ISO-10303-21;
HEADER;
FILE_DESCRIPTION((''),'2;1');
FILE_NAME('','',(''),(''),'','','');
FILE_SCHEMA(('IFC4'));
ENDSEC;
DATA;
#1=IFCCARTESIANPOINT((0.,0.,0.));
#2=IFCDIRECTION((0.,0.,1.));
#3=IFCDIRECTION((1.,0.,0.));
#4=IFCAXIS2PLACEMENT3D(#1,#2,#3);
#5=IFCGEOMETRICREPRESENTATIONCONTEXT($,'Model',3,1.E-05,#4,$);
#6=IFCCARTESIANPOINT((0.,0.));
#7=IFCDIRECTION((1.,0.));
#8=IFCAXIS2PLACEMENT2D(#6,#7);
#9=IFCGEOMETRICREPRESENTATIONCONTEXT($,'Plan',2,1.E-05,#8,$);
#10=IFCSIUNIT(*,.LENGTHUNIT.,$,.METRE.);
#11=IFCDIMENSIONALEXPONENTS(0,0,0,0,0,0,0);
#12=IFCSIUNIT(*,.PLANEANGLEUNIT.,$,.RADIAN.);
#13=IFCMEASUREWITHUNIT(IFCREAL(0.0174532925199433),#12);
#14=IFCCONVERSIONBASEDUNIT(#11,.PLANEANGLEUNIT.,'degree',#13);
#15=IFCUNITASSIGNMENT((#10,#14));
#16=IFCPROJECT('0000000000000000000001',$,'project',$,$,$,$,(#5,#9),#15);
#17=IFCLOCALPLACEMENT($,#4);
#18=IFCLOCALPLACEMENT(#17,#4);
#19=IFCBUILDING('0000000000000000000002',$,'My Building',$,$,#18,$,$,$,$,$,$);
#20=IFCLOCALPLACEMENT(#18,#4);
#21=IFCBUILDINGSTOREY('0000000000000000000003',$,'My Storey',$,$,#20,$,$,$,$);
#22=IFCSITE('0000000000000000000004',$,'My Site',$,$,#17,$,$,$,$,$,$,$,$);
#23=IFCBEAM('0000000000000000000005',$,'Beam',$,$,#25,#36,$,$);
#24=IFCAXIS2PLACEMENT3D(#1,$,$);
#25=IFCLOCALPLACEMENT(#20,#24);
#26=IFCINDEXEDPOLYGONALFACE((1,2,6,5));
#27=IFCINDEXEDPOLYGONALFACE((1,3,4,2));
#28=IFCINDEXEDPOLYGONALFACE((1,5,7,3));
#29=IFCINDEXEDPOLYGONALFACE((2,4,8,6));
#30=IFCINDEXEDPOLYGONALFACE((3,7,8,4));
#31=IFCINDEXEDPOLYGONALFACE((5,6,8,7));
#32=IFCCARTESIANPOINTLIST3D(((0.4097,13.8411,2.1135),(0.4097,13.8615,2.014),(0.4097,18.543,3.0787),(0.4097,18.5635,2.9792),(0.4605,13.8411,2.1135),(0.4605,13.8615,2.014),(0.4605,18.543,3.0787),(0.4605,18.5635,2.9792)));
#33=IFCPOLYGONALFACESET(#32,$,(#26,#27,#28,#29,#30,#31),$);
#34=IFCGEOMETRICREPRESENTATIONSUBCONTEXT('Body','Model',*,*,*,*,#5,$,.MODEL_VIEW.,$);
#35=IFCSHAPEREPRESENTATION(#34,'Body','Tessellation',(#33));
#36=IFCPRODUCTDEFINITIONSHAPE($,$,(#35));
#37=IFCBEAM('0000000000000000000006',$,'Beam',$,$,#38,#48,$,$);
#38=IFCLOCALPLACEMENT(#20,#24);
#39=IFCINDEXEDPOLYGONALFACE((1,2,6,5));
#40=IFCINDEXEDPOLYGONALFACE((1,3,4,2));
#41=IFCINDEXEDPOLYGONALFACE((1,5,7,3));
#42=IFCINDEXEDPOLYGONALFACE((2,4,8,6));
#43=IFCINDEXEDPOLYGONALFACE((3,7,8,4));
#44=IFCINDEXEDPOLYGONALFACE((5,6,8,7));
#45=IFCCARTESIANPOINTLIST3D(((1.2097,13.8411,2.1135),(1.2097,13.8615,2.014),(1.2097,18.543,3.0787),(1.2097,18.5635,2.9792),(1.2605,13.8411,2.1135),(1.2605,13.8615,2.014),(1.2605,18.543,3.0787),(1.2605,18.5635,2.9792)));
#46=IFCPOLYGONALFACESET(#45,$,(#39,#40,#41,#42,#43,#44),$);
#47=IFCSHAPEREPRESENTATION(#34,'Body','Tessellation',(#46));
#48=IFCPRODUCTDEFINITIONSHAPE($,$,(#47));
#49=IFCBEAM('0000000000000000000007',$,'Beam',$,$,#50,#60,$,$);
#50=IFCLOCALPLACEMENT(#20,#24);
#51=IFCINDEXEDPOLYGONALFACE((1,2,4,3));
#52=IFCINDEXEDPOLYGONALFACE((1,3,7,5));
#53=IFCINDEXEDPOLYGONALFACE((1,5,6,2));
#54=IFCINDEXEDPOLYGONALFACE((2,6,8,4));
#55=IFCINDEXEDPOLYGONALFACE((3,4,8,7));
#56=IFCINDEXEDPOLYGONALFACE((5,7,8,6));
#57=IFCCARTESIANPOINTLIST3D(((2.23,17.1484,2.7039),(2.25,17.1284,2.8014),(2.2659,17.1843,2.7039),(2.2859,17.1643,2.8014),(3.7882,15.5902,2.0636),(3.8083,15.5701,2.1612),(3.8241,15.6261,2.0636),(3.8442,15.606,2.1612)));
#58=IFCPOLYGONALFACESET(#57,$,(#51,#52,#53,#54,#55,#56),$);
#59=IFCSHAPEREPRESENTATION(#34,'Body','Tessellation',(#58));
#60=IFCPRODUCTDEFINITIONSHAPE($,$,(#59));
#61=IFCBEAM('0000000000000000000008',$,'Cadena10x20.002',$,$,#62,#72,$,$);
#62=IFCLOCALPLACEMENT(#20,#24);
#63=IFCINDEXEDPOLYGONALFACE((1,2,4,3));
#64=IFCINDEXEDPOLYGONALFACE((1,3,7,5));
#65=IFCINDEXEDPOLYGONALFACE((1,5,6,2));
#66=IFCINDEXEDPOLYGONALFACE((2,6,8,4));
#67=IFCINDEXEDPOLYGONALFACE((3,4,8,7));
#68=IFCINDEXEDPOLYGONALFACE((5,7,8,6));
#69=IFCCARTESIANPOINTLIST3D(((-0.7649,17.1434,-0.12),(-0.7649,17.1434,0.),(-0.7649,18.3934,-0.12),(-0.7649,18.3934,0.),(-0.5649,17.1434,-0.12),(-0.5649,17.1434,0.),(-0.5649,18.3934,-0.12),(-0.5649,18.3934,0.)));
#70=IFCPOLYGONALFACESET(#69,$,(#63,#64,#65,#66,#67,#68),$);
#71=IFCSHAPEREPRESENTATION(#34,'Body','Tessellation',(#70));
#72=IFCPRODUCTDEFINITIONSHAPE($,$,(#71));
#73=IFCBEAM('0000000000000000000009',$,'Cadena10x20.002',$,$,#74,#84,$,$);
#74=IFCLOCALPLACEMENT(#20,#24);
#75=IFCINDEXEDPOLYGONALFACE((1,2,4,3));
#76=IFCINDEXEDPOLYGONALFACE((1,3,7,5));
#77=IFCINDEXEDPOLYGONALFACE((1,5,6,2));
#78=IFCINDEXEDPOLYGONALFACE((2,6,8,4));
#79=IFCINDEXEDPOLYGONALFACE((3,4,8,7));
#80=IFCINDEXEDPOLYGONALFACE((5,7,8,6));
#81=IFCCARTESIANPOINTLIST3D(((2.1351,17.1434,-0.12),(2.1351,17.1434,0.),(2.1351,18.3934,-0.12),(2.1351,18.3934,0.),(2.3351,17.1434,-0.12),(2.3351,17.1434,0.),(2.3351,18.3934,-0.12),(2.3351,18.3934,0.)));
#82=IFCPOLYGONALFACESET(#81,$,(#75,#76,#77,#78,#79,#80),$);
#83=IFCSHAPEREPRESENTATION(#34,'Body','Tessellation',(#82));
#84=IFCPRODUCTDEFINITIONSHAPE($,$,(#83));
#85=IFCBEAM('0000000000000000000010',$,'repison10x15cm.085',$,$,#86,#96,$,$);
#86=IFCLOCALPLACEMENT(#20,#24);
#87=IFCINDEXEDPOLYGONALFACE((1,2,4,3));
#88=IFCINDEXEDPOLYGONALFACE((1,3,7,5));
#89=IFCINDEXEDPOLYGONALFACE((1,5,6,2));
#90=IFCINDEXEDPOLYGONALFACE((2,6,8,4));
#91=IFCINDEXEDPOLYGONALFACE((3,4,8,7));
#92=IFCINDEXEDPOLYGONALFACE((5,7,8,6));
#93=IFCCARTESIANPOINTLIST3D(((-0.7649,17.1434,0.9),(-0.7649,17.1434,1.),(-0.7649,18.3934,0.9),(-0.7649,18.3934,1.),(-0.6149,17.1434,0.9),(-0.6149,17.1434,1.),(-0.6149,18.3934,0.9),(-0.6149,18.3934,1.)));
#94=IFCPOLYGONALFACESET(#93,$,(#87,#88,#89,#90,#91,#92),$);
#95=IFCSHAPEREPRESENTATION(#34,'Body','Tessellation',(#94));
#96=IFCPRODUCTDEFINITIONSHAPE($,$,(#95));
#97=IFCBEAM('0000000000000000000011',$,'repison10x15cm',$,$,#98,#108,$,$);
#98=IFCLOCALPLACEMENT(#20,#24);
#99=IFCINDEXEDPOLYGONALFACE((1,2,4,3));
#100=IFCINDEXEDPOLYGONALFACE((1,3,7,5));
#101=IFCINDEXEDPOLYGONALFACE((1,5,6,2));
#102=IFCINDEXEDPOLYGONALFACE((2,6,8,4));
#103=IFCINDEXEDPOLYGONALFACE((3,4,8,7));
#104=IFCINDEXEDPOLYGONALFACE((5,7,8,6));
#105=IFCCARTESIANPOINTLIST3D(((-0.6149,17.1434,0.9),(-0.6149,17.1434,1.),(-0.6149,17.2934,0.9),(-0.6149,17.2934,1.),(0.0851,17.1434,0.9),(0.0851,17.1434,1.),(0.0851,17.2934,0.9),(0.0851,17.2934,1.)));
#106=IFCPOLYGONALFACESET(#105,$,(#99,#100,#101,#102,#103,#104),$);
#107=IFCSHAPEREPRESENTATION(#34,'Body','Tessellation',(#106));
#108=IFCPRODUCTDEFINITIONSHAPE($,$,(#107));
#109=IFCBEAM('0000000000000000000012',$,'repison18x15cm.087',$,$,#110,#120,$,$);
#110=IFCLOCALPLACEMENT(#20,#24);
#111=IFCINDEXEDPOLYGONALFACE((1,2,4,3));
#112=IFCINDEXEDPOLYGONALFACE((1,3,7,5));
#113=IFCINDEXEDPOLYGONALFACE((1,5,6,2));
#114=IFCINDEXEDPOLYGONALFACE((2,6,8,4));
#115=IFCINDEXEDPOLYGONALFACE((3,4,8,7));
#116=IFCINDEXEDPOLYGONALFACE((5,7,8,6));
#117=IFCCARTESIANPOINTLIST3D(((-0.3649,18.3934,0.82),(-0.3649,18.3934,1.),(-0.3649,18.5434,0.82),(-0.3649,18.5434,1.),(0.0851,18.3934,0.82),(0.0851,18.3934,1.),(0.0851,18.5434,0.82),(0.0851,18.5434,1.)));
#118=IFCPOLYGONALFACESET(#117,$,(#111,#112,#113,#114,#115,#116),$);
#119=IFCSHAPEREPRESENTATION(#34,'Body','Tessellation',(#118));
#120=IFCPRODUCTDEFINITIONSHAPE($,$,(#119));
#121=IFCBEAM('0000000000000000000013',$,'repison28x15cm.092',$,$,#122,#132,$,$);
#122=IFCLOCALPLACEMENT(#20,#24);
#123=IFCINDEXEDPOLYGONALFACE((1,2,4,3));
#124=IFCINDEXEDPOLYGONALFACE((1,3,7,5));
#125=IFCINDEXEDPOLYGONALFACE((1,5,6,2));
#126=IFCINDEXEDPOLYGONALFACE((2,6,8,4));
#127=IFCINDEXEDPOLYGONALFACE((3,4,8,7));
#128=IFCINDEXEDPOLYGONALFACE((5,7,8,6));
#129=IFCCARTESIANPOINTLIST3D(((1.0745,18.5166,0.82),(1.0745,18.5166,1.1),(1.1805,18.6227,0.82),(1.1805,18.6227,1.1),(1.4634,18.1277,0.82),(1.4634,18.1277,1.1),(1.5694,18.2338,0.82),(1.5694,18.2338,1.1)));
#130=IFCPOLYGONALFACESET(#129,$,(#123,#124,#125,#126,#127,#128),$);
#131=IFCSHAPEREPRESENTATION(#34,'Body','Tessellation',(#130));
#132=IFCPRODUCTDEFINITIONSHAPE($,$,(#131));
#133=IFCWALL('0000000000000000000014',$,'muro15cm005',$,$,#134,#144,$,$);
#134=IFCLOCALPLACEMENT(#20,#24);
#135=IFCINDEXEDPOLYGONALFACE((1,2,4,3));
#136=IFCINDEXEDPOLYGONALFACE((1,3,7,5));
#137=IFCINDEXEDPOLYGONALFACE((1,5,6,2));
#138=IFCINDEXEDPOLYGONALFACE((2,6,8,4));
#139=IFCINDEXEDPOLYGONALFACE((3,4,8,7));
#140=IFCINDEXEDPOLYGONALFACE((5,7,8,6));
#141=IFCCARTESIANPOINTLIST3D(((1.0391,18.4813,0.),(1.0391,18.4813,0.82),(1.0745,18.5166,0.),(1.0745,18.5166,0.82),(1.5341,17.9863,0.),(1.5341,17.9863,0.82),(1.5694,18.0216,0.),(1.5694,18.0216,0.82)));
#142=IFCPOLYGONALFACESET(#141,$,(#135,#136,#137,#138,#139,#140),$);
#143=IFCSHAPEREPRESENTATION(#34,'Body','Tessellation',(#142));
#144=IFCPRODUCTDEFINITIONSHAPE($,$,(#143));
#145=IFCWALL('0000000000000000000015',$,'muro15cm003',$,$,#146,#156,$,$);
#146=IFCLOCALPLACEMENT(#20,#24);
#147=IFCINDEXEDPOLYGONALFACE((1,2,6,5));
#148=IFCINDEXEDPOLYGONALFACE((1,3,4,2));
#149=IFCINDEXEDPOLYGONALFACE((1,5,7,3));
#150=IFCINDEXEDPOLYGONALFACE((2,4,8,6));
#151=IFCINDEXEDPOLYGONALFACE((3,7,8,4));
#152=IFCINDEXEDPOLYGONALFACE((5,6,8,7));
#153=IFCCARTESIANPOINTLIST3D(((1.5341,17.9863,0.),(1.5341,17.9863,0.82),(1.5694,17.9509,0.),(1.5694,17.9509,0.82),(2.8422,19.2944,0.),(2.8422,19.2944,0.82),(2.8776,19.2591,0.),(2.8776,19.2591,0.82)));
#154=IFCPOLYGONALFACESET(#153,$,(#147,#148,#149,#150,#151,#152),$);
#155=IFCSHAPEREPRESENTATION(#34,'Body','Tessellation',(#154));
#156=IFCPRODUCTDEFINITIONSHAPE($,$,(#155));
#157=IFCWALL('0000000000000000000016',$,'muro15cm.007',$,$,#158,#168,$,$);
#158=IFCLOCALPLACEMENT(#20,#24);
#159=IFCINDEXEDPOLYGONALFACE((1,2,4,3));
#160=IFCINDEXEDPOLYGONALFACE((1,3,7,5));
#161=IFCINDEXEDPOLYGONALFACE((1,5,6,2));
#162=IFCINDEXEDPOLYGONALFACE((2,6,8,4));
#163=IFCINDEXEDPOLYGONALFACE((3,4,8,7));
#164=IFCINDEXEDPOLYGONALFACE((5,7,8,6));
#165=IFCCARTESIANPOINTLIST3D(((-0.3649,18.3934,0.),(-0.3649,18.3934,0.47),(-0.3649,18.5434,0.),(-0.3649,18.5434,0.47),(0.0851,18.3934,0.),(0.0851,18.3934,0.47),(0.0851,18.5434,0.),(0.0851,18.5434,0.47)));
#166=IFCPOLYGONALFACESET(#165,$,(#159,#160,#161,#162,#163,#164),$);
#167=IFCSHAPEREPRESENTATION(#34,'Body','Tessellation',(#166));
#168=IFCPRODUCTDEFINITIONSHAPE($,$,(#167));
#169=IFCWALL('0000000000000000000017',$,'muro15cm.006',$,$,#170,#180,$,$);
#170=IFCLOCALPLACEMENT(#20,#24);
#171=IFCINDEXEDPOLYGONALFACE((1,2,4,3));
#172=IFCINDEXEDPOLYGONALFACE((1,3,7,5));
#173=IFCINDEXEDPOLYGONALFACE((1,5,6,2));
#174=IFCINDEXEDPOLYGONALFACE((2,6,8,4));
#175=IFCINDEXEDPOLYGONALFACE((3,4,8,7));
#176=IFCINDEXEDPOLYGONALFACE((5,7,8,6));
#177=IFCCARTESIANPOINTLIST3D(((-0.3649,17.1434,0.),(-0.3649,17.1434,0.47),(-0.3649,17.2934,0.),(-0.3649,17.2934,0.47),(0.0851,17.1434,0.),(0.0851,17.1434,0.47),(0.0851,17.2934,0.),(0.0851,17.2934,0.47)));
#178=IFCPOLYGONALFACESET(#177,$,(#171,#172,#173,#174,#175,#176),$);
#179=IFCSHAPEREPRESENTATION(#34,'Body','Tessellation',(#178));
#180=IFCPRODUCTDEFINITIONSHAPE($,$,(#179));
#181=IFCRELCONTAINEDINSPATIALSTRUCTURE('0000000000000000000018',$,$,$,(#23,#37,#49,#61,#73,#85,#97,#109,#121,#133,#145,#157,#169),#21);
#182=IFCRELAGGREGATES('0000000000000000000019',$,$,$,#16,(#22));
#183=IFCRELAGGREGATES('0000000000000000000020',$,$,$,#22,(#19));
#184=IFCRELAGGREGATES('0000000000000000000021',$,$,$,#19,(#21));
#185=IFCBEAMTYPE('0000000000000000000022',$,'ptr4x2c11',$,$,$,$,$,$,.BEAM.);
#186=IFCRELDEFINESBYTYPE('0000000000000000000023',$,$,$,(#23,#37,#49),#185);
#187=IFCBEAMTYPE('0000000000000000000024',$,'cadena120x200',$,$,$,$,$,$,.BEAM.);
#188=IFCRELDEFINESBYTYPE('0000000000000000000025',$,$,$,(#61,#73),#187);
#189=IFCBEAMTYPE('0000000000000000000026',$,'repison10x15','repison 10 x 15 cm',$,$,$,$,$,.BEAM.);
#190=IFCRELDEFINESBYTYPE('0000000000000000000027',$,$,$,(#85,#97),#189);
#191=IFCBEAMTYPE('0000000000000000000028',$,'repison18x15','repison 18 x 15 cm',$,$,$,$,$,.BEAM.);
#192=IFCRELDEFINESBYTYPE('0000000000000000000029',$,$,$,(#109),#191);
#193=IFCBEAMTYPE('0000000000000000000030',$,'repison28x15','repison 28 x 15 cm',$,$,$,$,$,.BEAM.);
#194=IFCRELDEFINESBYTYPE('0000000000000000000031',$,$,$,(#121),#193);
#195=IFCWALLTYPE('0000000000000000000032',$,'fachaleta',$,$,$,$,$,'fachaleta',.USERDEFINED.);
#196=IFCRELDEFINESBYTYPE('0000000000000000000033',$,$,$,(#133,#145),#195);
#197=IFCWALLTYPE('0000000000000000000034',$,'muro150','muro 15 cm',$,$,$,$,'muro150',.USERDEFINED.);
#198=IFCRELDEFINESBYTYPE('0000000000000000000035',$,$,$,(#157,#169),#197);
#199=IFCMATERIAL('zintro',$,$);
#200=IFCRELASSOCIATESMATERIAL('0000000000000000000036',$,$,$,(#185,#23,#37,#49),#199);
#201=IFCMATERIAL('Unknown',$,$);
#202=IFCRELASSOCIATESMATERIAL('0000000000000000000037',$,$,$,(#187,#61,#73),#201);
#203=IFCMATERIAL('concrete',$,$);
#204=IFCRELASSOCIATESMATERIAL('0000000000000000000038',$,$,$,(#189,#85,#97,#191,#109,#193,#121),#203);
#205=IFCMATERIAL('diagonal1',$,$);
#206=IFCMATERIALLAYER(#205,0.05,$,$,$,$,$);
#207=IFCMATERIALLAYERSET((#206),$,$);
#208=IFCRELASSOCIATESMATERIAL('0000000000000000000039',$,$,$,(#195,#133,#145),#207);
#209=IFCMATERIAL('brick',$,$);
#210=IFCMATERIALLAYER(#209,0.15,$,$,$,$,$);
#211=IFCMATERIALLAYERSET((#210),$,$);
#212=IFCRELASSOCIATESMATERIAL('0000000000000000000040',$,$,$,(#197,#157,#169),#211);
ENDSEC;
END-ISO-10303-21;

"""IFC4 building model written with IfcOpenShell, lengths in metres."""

from ifc_helpers import new_model, entity, si_unit, converted_unit, frame, origin_with_axes, origin_2d_with_axis, place, context, subcontext, project, spatial, indexed_curve, rectangle, outline, extrude, material, layer, layer_set, layer_usage, material_profile, profile_set, profile_usage, type_object, element, save


model = new_model("IFC4")

# Units and contexts
model_context = context("Model", 3, precision=1e-05, world=origin_with_axes())
plan_context = context("Plan", 2, precision=1e-05, world=origin_2d_with_axis())
body_context = subcontext(model_context, "Body", "Model", "MODEL_VIEW")
ifc_project = project(units=[si_unit("LENGTHUNIT", "METRE"), converted_unit("PLANEANGLEUNIT", "degree", entity("IfcReal", 0.0174532925199433), si_unit("PLANEANGLEUNIT", "RADIAN"), dimensions=[0, 0, 0, 0, 0, 0, 0])], contexts=[model_context, plan_context])

# Site, building, storey
site_placement = place(None, origin_with_axes())
site = spatial("IfcSite", under=ifc_project, at=site_placement, Name="My Site")
building_placement = place(site_placement, origin_with_axes())
building = spatial("IfcBuilding", under=site, at=building_placement, Name="My Building")
storey_placement = place(building_placement, origin_with_axes())
storey = spatial("IfcBuildingStorey", under=building, at=storey_placement, Name="My Storey")

# Shared definitions
ifc_material_1 = material(Name="concrete")

# Beams
ifc_material_2 = material(Name="zintro")
ifc_material_profile_1 = material_profile(ifc_material_2, rectangle(XDim=0.0508, YDim=0.1016))
ifc_profile_set_1 = profile_set([ifc_material_profile_1])
beam_type_1 = type_object("IfcBeamType", Name="ptr4x2c11", PredefinedType="BEAM", material=ifc_profile_set_1)
ifc_profile_usage_1 = profile_usage(ifc_profile_set_1)
beam_1_placement = place(storey_placement, frame((0.4351, 18.5532, 3.0289), z_axis=(0.0, -0.979575, -0.201078), x_axis=(1.0, 0.0, 0.0)))
element("IfcBeam", 1, at=beam_1_placement, inside=storey, type_object=beam_type_1, material=ifc_profile_usage_1, Name="Beam", context=body_context, shape_type="SweptSolid", body=[
    extrude(rectangle(XDim=0.0508, YDim=0.1016), origin_with_axes(), (0.0, 0.0, 1.0), 4.8),
])
ifc_profile_usage_2 = profile_usage(ifc_profile_set_1)
beam_2_placement = place(storey_placement, frame((1.2351, 18.5532, 3.0289), z_axis=(0.0, -0.979575, -0.201078), x_axis=(1.0, 0.0, 0.0)))
element("IfcBeam", 2, at=beam_2_placement, inside=storey, type_object=beam_type_1, material=ifc_profile_usage_2, Name="Beam", context=body_context, shape_type="SweptSolid", body=[
    extrude(rectangle(XDim=0.0508, YDim=0.1016), origin_with_axes(), (0.0, 0.0, 1.0), 4.8),
])
ifc_profile_usage_3 = profile_usage(ifc_profile_set_1)
beam_3_placement = place(storey_placement, frame((2.2579, 17.1564, 2.7527), z_axis=(0.67903, -0.67903, -0.278991), x_axis=(0.707107, 0.707107, 0.0)))
element("IfcBeam", 3, at=beam_3_placement, inside=storey, type_object=beam_type_1, material=ifc_profile_usage_3, Name="Beam", context=body_context, shape_type="SweptSolid", body=[
    extrude(rectangle(XDim=0.0508, YDim=0.1016), origin_with_axes(), (0.0, 0.0, 1.0), 2.2948),
])
ifc_material_3 = material(Name="Unknown")
ifc_material_profile_2 = material_profile(ifc_material_3, rectangle(XDim=0.2, YDim=0.12))
ifc_profile_set_2 = profile_set([ifc_material_profile_2], Name="concrete")
ifc_profile_usage_4 = profile_usage(ifc_profile_set_2, cardinal=5)
beam_type_2 = type_object("IfcBeamType", Name="cadena120x200", PredefinedType="BEAM", material=ifc_profile_set_2)
beam_4_placement = place(storey_placement, frame((-0.6649, 18.3934, -0.06), z_axis=(0.0, -1.0, 0.0), x_axis=(1.0, 0.0, 0.0)))
element("IfcBeam", 4, at=beam_4_placement, inside=storey, type_object=beam_type_2, material=ifc_profile_usage_4, Name="Cadena10x20.002", context=body_context, shape_type="SweptSolid", body=[
    extrude(rectangle(XDim=0.2, YDim=0.12), origin_with_axes(), (0.0, 0.0, 1.0), 1.25),
])
ifc_profile_usage_5 = profile_usage(ifc_profile_set_2, cardinal=5)
beam_5_placement = place(storey_placement, frame((2.2351, 18.3934, -0.06), z_axis=(0.0, -1.0, 0.0), x_axis=(1.0, 0.0, 0.0)))
element("IfcBeam", 5, at=beam_5_placement, inside=storey, type_object=beam_type_2, material=ifc_profile_usage_5, Name="Cadena10x20.002", context=body_context, shape_type="SweptSolid", body=[
    extrude(rectangle(XDim=0.2, YDim=0.12), origin_with_axes(), (0.0, 0.0, 1.0), 1.25),
])
ifc_material_profile_3 = material_profile(ifc_material_1, rectangle(XDim=0.15, YDim=0.1))
ifc_profile_set_3 = profile_set([ifc_material_profile_3])
ifc_profile_usage_6 = profile_usage(ifc_profile_set_3, cardinal=5)
beam_type_3 = type_object("IfcBeamType", Name="repison10x15", Description="repison 10 x 15 cm", PredefinedType="BEAM", material=ifc_profile_set_3)
beam_6_placement = place(storey_placement, frame((-0.6899, 18.3934, 0.95), z_axis=(0.0, -1.0, 0.0), x_axis=(1.0, 0.0, 0.0)))
element("IfcBeam", 6, at=beam_6_placement, inside=storey, type_object=beam_type_3, material=ifc_profile_usage_6, Name="repison10x15cm.085", context=body_context, shape_type="SweptSolid", body=[
    extrude(rectangle(XDim=0.15, YDim=0.1), origin_with_axes(), (0.0, 0.0, 1.0), 1.25),
])
ifc_profile_usage_7 = profile_usage(ifc_profile_set_3, cardinal=5)
beam_7_placement = place(storey_placement, frame((-0.6149, 17.2184, 0.95), z_axis=(1.0, 0.0, 0.0), x_axis=(0.0, 1.0, 0.0)))
element("IfcBeam", 7, at=beam_7_placement, inside=storey, type_object=beam_type_3, material=ifc_profile_usage_7, Name="repison10x15cm", context=body_context, shape_type="SweptSolid", body=[
    extrude(rectangle(XDim=0.15, YDim=0.1), origin_with_axes(), (0.0, 0.0, 1.0), 0.7),
])
ifc_material_profile_4 = material_profile(ifc_material_1, rectangle(XDim=0.15, YDim=0.18), Name="concrete")
ifc_profile_set_4 = profile_set([ifc_material_profile_4], Name="concrete")
ifc_profile_usage_8 = profile_usage(ifc_profile_set_4, cardinal=5)
beam_type_4 = type_object("IfcBeamType", Name="repison18x15", Description="repison 18 x 15 cm", PredefinedType="BEAM", material=ifc_profile_set_4)
beam_8_placement = place(storey_placement, frame((-0.3649, 18.4684, 0.91), z_axis=(1.0, 0.0, 0.0), x_axis=(0.0, 1.0, 0.0)))
element("IfcBeam", 8, at=beam_8_placement, inside=storey, type_object=beam_type_4, material=ifc_profile_usage_8, Name="repison18x15cm.087", context=body_context, shape_type="SweptSolid", body=[
    extrude(rectangle(XDim=0.15, YDim=0.18), origin_with_axes(), (0.0, 0.0, 1.0), 0.45),
])
ifc_material_profile_5 = material_profile(ifc_material_1, rectangle(XDim=0.15, YDim=0.28))
ifc_profile_set_5 = profile_set([ifc_material_profile_5])
ifc_profile_usage_9 = profile_usage(ifc_profile_set_5, cardinal=5)
beam_type_5 = type_object("IfcBeamType", Name="repison28x15", Description="repison 28 x 15 cm", PredefinedType="BEAM", material=ifc_profile_set_5)
beam_9_placement = place(storey_placement, frame((1.1275, 18.5697, 0.96), z_axis=(0.707107, -0.707107, 0.0), x_axis=(0.707107, 0.707107, 0.0)))
element("IfcBeam", 9, at=beam_9_placement, inside=storey, type_object=beam_type_5, material=ifc_profile_usage_9, Name="repison28x15cm.092", context=body_context, shape_type="SweptSolid", body=[
    extrude(rectangle(XDim=0.15, YDim=0.28), origin_with_axes(), (0.0, 0.0, 1.0), 0.55),
])

# Walls
ifc_material_4 = material(Name="diagonal1")
ifc_layer_1 = layer(ifc_material_4, 0.05)
ifc_layer_set_1 = layer_set([ifc_layer_1])
ifc_layer_usage_1 = layer_usage(ifc_layer_set_1, "AXIS2", "POSITIVE", 0.0)
wall_type_1 = type_object("IfcWallType", Name="fachaleta", ElementType="fachaleta", PredefinedType="USERDEFINED", material=ifc_layer_set_1)
wall_1_placement = place(storey_placement, frame((1.0391, 18.4813, 0.0), z_axis=(0.0, 0.0, 1.0), x_axis=(0.707107, -0.707107, 0.0)))
element("IfcWall", 10, at=wall_1_placement, inside=storey, type_object=wall_type_1, material=ifc_layer_usage_1, Name="muro15cm005", context=body_context, shape_type="SweptSolid", body=[
    extrude(outline(indexed_curve([(0.0, 0.0), (0.0, 0.05), (0.7, 0.05), (0.7, 0.0), (0.0, 0.0)], self_intersect=False)), origin_with_axes(), (0.0, 0.0, 1.0), 0.82),
])
ifc_layer_usage_2 = layer_usage(ifc_layer_set_1, "AXIS2", "POSITIVE", 0.0)
wall_2_placement = place(storey_placement, frame((1.5694, 17.9509, 0.0), z_axis=(0.0, 0.0, 1.0), x_axis=(0.707107, 0.707107, 0.0)))
element("IfcWall", 11, at=wall_2_placement, inside=storey, type_object=wall_type_1, material=ifc_layer_usage_2, Name="muro15cm003", context=body_context, shape_type="SweptSolid", body=[
    extrude(outline(indexed_curve([(0.0, 0.0), (0.0, 0.05), (1.85, 0.05), (1.85, 0.0), (0.0, 0.0)], self_intersect=False)), origin_with_axes(), (0.0, 0.0, 1.0), 0.82),
])
ifc_material_5 = material(Name="brick")
ifc_layer_2 = layer(ifc_material_5, 0.15)
ifc_layer_set_2 = layer_set([ifc_layer_2])
ifc_layer_usage_3 = layer_usage(ifc_layer_set_2, "AXIS2", "POSITIVE", 0.0)
wall_type_2 = type_object("IfcWallType", Name="muro150", Description="muro 15 cm", ElementType="muro150", PredefinedType="USERDEFINED", material=ifc_layer_set_2)
wall_3_placement = place(storey_placement, frame((-0.3649, 18.3934, 0.0), z_axis=(0.0, 0.0, 1.0), x_axis=(1.0, 0.0, 0.0)))
element("IfcWall", 12, at=wall_3_placement, inside=storey, type_object=wall_type_2, material=ifc_layer_usage_3, Name="muro15cm.007", context=body_context, shape_type="SweptSolid", body=[
    extrude(outline(indexed_curve([(0.0, 0.0), (0.0, 0.15), (0.45, 0.15), (0.45, 0.0), (0.0, 0.0)], self_intersect=False)), origin_with_axes(), (0.0, 0.0, 1.0), 0.47),
])
ifc_layer_usage_4 = layer_usage(ifc_layer_set_2, "AXIS2", "POSITIVE", 0.0)
wall_4_placement = place(storey_placement, frame((-0.3649, 17.1434, 0.0), z_axis=(0.0, 0.0, 1.0), x_axis=(1.0, 0.0, 0.0)))
element("IfcWall", 13, at=wall_4_placement, inside=storey, type_object=wall_type_2, material=ifc_layer_usage_4, Name="muro15cm.006", context=body_context, shape_type="SweptSolid", body=[
    extrude(outline(indexed_curve([(0.0, 0.0), (0.0, 0.15), (0.45, 0.15), (0.45, 0.0), (0.0, 0.0)], self_intersect=False)), origin_with_axes(), (0.0, 0.0, 1.0), 0.47),
])

save(model, "model.ifc")
